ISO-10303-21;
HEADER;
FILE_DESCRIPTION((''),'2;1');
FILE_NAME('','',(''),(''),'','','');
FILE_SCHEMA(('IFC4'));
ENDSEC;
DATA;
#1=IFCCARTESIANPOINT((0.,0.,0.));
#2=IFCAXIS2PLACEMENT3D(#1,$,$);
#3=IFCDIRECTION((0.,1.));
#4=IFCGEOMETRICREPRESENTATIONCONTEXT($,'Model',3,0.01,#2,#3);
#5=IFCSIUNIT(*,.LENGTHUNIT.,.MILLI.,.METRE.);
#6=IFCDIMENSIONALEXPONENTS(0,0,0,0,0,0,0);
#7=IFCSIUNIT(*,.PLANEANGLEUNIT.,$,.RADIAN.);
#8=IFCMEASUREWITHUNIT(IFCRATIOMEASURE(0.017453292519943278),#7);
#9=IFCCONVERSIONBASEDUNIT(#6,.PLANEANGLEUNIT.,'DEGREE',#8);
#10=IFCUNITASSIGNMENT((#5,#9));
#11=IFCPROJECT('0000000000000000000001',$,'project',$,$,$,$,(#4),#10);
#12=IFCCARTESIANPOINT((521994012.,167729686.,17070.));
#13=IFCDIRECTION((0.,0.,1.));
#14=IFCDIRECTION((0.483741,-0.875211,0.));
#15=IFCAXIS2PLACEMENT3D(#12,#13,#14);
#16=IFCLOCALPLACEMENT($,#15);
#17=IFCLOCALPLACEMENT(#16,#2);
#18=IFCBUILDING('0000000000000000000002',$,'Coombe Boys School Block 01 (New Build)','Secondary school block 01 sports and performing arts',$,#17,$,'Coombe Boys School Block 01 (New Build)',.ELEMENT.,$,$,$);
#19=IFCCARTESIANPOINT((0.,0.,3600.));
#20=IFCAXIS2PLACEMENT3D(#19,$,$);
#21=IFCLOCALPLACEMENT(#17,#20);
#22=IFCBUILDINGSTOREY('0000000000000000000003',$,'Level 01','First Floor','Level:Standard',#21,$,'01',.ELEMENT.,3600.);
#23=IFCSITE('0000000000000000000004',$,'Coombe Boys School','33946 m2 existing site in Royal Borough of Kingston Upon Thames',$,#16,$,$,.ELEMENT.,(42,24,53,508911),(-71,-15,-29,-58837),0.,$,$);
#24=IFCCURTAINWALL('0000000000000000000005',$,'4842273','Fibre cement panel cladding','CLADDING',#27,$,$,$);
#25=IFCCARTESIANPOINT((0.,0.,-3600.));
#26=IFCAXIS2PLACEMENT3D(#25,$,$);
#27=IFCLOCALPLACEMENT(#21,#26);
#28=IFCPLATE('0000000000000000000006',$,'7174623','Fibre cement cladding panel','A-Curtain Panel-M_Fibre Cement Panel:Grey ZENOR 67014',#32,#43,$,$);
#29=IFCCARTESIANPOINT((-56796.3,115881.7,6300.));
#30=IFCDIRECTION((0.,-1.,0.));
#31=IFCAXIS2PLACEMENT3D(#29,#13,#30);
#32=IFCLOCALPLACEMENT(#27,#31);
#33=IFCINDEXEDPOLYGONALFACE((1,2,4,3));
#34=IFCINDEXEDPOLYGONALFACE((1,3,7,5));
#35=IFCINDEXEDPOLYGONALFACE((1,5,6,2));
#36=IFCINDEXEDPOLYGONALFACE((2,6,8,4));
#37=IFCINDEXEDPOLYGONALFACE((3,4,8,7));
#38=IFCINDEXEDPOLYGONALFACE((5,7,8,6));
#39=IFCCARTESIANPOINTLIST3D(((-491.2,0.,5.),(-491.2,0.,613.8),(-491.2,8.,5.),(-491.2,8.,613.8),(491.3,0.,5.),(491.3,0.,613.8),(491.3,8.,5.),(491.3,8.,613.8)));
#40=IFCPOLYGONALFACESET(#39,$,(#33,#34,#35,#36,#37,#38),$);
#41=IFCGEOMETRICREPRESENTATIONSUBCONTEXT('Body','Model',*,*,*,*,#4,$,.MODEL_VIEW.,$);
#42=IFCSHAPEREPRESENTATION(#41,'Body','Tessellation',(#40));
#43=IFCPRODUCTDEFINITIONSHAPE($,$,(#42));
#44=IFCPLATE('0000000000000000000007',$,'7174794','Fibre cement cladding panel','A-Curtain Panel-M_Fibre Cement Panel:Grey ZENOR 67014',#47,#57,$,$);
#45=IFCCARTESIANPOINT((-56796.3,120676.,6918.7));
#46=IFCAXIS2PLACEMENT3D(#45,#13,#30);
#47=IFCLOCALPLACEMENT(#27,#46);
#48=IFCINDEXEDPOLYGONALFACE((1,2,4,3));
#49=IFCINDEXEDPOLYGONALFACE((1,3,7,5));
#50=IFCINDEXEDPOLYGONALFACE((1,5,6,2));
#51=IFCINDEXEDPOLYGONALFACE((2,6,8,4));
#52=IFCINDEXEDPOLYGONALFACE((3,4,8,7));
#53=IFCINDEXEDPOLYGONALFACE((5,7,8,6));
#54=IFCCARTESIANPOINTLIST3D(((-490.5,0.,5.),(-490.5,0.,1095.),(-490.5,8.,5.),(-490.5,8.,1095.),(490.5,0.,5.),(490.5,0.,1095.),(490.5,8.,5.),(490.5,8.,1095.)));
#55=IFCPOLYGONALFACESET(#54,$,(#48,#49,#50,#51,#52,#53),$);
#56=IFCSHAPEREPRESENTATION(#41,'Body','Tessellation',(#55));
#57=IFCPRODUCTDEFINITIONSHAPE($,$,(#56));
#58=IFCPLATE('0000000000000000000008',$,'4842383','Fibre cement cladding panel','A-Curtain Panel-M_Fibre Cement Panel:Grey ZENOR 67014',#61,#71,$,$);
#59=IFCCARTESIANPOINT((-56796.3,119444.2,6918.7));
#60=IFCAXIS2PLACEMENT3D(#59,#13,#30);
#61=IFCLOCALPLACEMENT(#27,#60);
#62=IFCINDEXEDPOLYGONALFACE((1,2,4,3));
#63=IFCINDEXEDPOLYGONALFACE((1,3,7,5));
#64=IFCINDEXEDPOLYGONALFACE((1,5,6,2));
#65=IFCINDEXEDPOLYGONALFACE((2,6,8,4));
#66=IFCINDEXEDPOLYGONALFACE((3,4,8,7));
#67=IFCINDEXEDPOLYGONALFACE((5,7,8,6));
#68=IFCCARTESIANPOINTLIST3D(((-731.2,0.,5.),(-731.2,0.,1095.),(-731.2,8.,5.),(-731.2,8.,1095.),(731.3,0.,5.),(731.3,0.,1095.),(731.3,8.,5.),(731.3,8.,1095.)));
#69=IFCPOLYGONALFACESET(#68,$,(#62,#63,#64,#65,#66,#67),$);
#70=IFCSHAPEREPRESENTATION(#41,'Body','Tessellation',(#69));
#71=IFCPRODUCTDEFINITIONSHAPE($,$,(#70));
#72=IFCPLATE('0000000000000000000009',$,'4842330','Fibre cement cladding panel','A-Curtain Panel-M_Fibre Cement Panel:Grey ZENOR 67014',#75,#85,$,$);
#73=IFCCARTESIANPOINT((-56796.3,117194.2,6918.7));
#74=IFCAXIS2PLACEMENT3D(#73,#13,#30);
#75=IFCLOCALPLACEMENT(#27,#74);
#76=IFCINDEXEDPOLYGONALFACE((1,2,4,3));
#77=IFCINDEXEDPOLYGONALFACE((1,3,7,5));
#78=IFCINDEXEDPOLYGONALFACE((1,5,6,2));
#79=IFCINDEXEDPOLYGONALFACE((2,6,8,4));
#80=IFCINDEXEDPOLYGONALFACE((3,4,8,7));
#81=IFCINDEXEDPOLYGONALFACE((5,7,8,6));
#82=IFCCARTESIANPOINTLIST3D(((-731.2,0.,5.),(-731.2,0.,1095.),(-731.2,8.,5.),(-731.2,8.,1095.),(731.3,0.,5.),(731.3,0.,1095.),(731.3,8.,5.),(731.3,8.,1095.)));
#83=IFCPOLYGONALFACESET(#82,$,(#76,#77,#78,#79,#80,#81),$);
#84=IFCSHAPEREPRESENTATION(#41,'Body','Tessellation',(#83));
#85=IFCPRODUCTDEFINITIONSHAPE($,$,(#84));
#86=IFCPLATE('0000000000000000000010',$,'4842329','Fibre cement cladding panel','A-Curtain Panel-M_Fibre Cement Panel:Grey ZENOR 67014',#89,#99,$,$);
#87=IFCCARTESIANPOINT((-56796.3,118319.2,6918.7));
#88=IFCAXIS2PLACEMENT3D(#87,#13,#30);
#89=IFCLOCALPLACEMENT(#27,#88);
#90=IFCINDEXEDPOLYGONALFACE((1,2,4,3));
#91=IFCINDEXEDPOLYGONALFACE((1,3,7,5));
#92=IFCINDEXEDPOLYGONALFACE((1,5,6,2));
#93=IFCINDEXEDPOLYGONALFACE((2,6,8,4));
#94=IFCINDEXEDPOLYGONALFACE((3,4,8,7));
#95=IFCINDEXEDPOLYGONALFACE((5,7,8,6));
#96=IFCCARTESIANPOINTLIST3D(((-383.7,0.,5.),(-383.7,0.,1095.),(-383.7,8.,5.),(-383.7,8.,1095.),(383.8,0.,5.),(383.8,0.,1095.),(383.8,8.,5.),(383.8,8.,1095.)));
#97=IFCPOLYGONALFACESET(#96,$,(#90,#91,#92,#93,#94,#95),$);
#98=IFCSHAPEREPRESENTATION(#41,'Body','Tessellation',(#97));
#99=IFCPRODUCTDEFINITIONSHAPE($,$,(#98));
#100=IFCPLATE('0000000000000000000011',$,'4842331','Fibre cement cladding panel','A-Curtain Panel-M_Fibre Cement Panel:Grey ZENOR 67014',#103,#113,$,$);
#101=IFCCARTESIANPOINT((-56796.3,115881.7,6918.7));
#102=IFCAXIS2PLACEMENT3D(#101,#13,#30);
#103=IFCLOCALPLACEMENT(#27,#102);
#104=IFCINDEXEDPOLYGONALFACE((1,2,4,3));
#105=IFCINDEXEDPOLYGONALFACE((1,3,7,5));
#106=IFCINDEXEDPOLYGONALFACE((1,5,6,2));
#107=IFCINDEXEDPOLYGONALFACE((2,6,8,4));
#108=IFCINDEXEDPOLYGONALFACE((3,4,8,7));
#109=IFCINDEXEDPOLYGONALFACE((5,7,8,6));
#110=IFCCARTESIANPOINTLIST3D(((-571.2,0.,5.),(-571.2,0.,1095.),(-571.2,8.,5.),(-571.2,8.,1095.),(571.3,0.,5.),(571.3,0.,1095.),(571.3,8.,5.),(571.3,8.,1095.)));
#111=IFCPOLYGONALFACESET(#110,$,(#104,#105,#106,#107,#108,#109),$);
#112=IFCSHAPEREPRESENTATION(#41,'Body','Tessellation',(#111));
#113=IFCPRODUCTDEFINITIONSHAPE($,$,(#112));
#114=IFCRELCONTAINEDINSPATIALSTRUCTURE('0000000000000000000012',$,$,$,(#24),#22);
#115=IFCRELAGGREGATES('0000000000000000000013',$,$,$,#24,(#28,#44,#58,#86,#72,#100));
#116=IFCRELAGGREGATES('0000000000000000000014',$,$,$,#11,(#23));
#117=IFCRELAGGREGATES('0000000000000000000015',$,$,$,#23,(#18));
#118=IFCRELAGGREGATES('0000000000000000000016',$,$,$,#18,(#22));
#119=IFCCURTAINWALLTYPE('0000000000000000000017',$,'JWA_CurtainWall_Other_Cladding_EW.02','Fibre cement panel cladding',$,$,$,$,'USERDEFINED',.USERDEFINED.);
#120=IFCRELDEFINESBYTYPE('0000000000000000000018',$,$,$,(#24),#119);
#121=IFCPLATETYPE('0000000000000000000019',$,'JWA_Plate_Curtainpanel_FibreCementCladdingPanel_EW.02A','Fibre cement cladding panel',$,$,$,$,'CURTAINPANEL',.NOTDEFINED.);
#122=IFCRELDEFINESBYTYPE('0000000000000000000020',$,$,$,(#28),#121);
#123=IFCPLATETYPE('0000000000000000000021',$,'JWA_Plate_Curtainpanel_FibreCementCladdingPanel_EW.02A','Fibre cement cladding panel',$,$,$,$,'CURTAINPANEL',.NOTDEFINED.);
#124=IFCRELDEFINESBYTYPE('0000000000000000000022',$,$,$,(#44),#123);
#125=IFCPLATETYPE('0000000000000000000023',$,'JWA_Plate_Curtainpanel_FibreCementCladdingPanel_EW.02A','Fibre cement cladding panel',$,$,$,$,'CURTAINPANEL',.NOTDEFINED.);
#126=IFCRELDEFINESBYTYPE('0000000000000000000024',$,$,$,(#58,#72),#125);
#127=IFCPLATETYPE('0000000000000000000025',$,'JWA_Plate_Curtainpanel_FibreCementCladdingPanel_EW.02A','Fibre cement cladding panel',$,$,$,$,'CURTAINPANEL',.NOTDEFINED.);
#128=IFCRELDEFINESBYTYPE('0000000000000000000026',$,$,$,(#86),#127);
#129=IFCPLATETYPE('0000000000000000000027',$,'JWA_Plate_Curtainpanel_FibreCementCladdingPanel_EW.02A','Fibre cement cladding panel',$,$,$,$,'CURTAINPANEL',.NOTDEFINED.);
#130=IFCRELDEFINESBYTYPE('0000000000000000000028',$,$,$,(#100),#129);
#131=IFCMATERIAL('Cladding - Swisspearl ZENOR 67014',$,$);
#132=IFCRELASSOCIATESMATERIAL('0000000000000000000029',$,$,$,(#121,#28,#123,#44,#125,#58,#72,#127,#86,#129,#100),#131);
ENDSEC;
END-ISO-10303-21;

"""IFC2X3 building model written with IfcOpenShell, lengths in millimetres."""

from ifc_helpers import new_model, entity, si_unit, converted_unit, direction, frame, origin, origin_2d_with_axis, place, context, subcontext, project, spatial, rectangle, extrude, source, transform, mapped, material, type_object, type_shapes, element, aggregate, save


model = new_model("IFC2X3")

# Units and contexts
model_context = context("Model", 3, precision=0.01, world=origin(), true_north=direction((0.0, 1.0)))
body_context = subcontext(model_context, "Body", "Model", "MODEL_VIEW")
ifc_project = project(units=[si_unit("LENGTHUNIT", "METRE", prefix="MILLI"), converted_unit("PLANEANGLEUNIT", "DEGREE", entity("IfcRatioMeasure", 0.017453292519943278), si_unit("PLANEANGLEUNIT", "RADIAN"), dimensions=[0, 0, 0, 0, 0, 0, 0])], contexts=[model_context])

# Site, building, storey
site_placement = place(None, frame((521994012.0, 167729686.0, 17070.0), z_axis=(0.0, 0.0, 1.0), x_axis=(0.483741, -0.875211, 0.0)))
site = spatial("IfcSite", under=ifc_project, at=site_placement, Name="Coombe Boys School", Description="33946 m2 existing site in Royal Borough of Kingston Upon Thames", CompositionType="ELEMENT", RefLatitude=(42, 24, 53, 508911), RefLongitude=(-71, -15, -29, -58837), RefElevation=0.0)
building_placement = place(site_placement, origin())
building = spatial("IfcBuilding", under=site, at=building_placement, Name="Coombe Boys School Block 01 (New Build)", Description="Secondary school block 01 sports and performing arts", LongName="Coombe Boys School Block 01 (New Build)", CompositionType="ELEMENT")
storey_placement = place(building_placement, frame((0.0, 0.0, 3600.0)))
storey = spatial("IfcBuildingStorey", under=building, at=storey_placement, Name="Level 01", Description="First Floor", ObjectType="Level:Standard", LongName="01", CompositionType="ELEMENT", Elevation=3600.0)

# Curtain wall, plates
curtain_wall_type = type_object("IfcCurtainWallType", Name="JWA_CurtainWall_Other_Cladding_EW.02", Description="Fibre cement panel cladding", ElementType="USERDEFINED", PredefinedType="USERDEFINED")
curtain_wall_placement = place(storey_placement, frame((0.0, 0.0, -3600.0)))
curtain_wall = element("IfcCurtainWall", 1, at=curtain_wall_placement, inside=storey, type_object=curtain_wall_type, Name="4842273", Description="Fibre cement panel cladding", ObjectType="CLADDING")
ifc_material_1 = material(Name="Cladding - Swisspearl ZENOR 67014")
plate_type_1 = type_object("IfcPlateType", Name="JWA_Plate_Curtainpanel_FibreCementCladdingPanel_EW.02A", Description="Fibre cement cladding panel", ElementType="CURTAINPANEL", PredefinedType="NOTDEFINED", material=ifc_material_1)
shared_shape_1 = source(origin(), body_context, "Body", "SweptSolid", [
    extrude(rectangle(XDim=8.0, YDim=982.5, at=origin_2d_with_axis()), frame((0.0, 4.0, 5.0), z_axis=(0.0, 0.0, 1.0), x_axis=(0.0, 1.0, 0.0)), (0.0, 0.0, 1.0), 608.8),
])
type_shapes(plate_type_1, [shared_shape_1])
plate_1_placement = place(curtain_wall_placement, frame((-56796.3, 115881.7, 6300.0), z_axis=(0.0, 0.0, 1.0), x_axis=(0.0, -1.0, 0.0)))
plate_1 = element("IfcPlate", 2, at=plate_1_placement, type_object=plate_type_1, material=ifc_material_1, Name="7174623", Description="Fibre cement cladding panel", ObjectType="A-Curtain Panel-M_Fibre Cement Panel:Grey ZENOR 67014", context=body_context, shape_type="MappedRepresentation", body=[
    mapped(shared_shape_1, transform((0.0, 0.0, 0.0), scale=1.0)),
])
plate_type_2 = type_object("IfcPlateType", Name="JWA_Plate_Curtainpanel_FibreCementCladdingPanel_EW.02A", Description="Fibre cement cladding panel", ElementType="CURTAINPANEL", PredefinedType="NOTDEFINED", material=ifc_material_1)
shared_shape_2 = source(origin(), body_context, "Body", "SweptSolid", [
    extrude(rectangle(XDim=8.0, YDim=981.0, at=origin_2d_with_axis()), frame((0.0, 4.0, 5.0), z_axis=(0.0, 0.0, 1.0), x_axis=(0.0, 1.0, 0.0)), (0.0, 0.0, 1.0), 1090.0),
])
type_shapes(plate_type_2, [shared_shape_2])
plate_2_placement = place(curtain_wall_placement, frame((-56796.3, 120676.0, 6918.7), z_axis=(0.0, 0.0, 1.0), x_axis=(0.0, -1.0, 0.0)))
plate_2 = element("IfcPlate", 3, at=plate_2_placement, type_object=plate_type_2, material=ifc_material_1, Name="7174794", Description="Fibre cement cladding panel", ObjectType="A-Curtain Panel-M_Fibre Cement Panel:Grey ZENOR 67014", context=body_context, shape_type="MappedRepresentation", body=[
    mapped(shared_shape_2, transform((0.0, 0.0, 0.0), scale=1.0)),
])
plate_type_3 = type_object("IfcPlateType", Name="JWA_Plate_Curtainpanel_FibreCementCladdingPanel_EW.02A", Description="Fibre cement cladding panel", ElementType="CURTAINPANEL", PredefinedType="NOTDEFINED", material=ifc_material_1)
shared_shape_3 = source(origin(), body_context, "Body", "SweptSolid", [
    extrude(rectangle(XDim=8.0, YDim=1462.5, at=origin_2d_with_axis()), frame((0.0, 4.0, 5.0), z_axis=(0.0, 0.0, 1.0), x_axis=(0.0, 1.0, 0.0)), (0.0, 0.0, 1.0), 1090.0),
])
type_shapes(plate_type_3, [shared_shape_3])
plate_3_placement = place(curtain_wall_placement, frame((-56796.3, 119444.2, 6918.7), z_axis=(0.0, 0.0, 1.0), x_axis=(0.0, -1.0, 0.0)))
plate_3 = element("IfcPlate", 4, at=plate_3_placement, type_object=plate_type_3, material=ifc_material_1, Name="4842383", Description="Fibre cement cladding panel", ObjectType="A-Curtain Panel-M_Fibre Cement Panel:Grey ZENOR 67014", context=body_context, shape_type="MappedRepresentation", body=[
    mapped(shared_shape_3, transform((0.0, 0.0, 0.0), scale=1.0)),
])
plate_4_placement = place(curtain_wall_placement, frame((-56796.3, 117194.2, 6918.7), z_axis=(0.0, 0.0, 1.0), x_axis=(0.0, -1.0, 0.0)))
plate_4 = element("IfcPlate", 5, at=plate_4_placement, type_object=plate_type_3, material=ifc_material_1, Name="4842330", Description="Fibre cement cladding panel", ObjectType="A-Curtain Panel-M_Fibre Cement Panel:Grey ZENOR 67014", context=body_context, shape_type="MappedRepresentation", body=[
    mapped(shared_shape_3, transform((0.0, 0.0, 0.0), scale=1.0)),
])
plate_type_4 = type_object("IfcPlateType", Name="JWA_Plate_Curtainpanel_FibreCementCladdingPanel_EW.02A", Description="Fibre cement cladding panel", ElementType="CURTAINPANEL", PredefinedType="NOTDEFINED", material=ifc_material_1)
shared_shape_4 = source(origin(), body_context, "Body", "SweptSolid", [
    extrude(rectangle(XDim=8.0, YDim=767.5, at=origin_2d_with_axis()), frame((0.0, 4.0, 5.0), z_axis=(0.0, 0.0, 1.0), x_axis=(0.0, 1.0, 0.0)), (0.0, 0.0, 1.0), 1090.0),
])
type_shapes(plate_type_4, [shared_shape_4])
plate_5_placement = place(curtain_wall_placement, frame((-56796.3, 118319.2, 6918.7), z_axis=(0.0, 0.0, 1.0), x_axis=(0.0, -1.0, 0.0)))
plate_5 = element("IfcPlate", 6, at=plate_5_placement, type_object=plate_type_4, material=ifc_material_1, Name="4842329", Description="Fibre cement cladding panel", ObjectType="A-Curtain Panel-M_Fibre Cement Panel:Grey ZENOR 67014", context=body_context, shape_type="MappedRepresentation", body=[
    mapped(shared_shape_4, transform((0.0, 0.0, 0.0), scale=1.0)),
])
plate_type_5 = type_object("IfcPlateType", Name="JWA_Plate_Curtainpanel_FibreCementCladdingPanel_EW.02A", Description="Fibre cement cladding panel", ElementType="CURTAINPANEL", PredefinedType="NOTDEFINED", material=ifc_material_1)
shared_shape_5 = source(origin(), body_context, "Body", "SweptSolid", [
    extrude(rectangle(XDim=8.0, YDim=1142.5, at=origin_2d_with_axis()), frame((0.0, 4.0, 5.0), z_axis=(0.0, 0.0, 1.0), x_axis=(0.0, 1.0, 0.0)), (0.0, 0.0, 1.0), 1090.0),
])
type_shapes(plate_type_5, [shared_shape_5])
plate_6_placement = place(curtain_wall_placement, frame((-56796.3, 115881.7, 6918.7), z_axis=(0.0, 0.0, 1.0), x_axis=(0.0, -1.0, 0.0)))
plate_6 = element("IfcPlate", 7, at=plate_6_placement, type_object=plate_type_5, material=ifc_material_1, Name="4842331", Description="Fibre cement cladding panel", ObjectType="A-Curtain Panel-M_Fibre Cement Panel:Grey ZENOR 67014", context=body_context, shape_type="MappedRepresentation", body=[
    mapped(shared_shape_5, transform((0.0, 0.0, 0.0), scale=1.0)),
])
aggregate(curtain_wall, [plate_1, plate_2, plate_3, plate_5, plate_4, plate_6])

save(model, "model.ifc")
